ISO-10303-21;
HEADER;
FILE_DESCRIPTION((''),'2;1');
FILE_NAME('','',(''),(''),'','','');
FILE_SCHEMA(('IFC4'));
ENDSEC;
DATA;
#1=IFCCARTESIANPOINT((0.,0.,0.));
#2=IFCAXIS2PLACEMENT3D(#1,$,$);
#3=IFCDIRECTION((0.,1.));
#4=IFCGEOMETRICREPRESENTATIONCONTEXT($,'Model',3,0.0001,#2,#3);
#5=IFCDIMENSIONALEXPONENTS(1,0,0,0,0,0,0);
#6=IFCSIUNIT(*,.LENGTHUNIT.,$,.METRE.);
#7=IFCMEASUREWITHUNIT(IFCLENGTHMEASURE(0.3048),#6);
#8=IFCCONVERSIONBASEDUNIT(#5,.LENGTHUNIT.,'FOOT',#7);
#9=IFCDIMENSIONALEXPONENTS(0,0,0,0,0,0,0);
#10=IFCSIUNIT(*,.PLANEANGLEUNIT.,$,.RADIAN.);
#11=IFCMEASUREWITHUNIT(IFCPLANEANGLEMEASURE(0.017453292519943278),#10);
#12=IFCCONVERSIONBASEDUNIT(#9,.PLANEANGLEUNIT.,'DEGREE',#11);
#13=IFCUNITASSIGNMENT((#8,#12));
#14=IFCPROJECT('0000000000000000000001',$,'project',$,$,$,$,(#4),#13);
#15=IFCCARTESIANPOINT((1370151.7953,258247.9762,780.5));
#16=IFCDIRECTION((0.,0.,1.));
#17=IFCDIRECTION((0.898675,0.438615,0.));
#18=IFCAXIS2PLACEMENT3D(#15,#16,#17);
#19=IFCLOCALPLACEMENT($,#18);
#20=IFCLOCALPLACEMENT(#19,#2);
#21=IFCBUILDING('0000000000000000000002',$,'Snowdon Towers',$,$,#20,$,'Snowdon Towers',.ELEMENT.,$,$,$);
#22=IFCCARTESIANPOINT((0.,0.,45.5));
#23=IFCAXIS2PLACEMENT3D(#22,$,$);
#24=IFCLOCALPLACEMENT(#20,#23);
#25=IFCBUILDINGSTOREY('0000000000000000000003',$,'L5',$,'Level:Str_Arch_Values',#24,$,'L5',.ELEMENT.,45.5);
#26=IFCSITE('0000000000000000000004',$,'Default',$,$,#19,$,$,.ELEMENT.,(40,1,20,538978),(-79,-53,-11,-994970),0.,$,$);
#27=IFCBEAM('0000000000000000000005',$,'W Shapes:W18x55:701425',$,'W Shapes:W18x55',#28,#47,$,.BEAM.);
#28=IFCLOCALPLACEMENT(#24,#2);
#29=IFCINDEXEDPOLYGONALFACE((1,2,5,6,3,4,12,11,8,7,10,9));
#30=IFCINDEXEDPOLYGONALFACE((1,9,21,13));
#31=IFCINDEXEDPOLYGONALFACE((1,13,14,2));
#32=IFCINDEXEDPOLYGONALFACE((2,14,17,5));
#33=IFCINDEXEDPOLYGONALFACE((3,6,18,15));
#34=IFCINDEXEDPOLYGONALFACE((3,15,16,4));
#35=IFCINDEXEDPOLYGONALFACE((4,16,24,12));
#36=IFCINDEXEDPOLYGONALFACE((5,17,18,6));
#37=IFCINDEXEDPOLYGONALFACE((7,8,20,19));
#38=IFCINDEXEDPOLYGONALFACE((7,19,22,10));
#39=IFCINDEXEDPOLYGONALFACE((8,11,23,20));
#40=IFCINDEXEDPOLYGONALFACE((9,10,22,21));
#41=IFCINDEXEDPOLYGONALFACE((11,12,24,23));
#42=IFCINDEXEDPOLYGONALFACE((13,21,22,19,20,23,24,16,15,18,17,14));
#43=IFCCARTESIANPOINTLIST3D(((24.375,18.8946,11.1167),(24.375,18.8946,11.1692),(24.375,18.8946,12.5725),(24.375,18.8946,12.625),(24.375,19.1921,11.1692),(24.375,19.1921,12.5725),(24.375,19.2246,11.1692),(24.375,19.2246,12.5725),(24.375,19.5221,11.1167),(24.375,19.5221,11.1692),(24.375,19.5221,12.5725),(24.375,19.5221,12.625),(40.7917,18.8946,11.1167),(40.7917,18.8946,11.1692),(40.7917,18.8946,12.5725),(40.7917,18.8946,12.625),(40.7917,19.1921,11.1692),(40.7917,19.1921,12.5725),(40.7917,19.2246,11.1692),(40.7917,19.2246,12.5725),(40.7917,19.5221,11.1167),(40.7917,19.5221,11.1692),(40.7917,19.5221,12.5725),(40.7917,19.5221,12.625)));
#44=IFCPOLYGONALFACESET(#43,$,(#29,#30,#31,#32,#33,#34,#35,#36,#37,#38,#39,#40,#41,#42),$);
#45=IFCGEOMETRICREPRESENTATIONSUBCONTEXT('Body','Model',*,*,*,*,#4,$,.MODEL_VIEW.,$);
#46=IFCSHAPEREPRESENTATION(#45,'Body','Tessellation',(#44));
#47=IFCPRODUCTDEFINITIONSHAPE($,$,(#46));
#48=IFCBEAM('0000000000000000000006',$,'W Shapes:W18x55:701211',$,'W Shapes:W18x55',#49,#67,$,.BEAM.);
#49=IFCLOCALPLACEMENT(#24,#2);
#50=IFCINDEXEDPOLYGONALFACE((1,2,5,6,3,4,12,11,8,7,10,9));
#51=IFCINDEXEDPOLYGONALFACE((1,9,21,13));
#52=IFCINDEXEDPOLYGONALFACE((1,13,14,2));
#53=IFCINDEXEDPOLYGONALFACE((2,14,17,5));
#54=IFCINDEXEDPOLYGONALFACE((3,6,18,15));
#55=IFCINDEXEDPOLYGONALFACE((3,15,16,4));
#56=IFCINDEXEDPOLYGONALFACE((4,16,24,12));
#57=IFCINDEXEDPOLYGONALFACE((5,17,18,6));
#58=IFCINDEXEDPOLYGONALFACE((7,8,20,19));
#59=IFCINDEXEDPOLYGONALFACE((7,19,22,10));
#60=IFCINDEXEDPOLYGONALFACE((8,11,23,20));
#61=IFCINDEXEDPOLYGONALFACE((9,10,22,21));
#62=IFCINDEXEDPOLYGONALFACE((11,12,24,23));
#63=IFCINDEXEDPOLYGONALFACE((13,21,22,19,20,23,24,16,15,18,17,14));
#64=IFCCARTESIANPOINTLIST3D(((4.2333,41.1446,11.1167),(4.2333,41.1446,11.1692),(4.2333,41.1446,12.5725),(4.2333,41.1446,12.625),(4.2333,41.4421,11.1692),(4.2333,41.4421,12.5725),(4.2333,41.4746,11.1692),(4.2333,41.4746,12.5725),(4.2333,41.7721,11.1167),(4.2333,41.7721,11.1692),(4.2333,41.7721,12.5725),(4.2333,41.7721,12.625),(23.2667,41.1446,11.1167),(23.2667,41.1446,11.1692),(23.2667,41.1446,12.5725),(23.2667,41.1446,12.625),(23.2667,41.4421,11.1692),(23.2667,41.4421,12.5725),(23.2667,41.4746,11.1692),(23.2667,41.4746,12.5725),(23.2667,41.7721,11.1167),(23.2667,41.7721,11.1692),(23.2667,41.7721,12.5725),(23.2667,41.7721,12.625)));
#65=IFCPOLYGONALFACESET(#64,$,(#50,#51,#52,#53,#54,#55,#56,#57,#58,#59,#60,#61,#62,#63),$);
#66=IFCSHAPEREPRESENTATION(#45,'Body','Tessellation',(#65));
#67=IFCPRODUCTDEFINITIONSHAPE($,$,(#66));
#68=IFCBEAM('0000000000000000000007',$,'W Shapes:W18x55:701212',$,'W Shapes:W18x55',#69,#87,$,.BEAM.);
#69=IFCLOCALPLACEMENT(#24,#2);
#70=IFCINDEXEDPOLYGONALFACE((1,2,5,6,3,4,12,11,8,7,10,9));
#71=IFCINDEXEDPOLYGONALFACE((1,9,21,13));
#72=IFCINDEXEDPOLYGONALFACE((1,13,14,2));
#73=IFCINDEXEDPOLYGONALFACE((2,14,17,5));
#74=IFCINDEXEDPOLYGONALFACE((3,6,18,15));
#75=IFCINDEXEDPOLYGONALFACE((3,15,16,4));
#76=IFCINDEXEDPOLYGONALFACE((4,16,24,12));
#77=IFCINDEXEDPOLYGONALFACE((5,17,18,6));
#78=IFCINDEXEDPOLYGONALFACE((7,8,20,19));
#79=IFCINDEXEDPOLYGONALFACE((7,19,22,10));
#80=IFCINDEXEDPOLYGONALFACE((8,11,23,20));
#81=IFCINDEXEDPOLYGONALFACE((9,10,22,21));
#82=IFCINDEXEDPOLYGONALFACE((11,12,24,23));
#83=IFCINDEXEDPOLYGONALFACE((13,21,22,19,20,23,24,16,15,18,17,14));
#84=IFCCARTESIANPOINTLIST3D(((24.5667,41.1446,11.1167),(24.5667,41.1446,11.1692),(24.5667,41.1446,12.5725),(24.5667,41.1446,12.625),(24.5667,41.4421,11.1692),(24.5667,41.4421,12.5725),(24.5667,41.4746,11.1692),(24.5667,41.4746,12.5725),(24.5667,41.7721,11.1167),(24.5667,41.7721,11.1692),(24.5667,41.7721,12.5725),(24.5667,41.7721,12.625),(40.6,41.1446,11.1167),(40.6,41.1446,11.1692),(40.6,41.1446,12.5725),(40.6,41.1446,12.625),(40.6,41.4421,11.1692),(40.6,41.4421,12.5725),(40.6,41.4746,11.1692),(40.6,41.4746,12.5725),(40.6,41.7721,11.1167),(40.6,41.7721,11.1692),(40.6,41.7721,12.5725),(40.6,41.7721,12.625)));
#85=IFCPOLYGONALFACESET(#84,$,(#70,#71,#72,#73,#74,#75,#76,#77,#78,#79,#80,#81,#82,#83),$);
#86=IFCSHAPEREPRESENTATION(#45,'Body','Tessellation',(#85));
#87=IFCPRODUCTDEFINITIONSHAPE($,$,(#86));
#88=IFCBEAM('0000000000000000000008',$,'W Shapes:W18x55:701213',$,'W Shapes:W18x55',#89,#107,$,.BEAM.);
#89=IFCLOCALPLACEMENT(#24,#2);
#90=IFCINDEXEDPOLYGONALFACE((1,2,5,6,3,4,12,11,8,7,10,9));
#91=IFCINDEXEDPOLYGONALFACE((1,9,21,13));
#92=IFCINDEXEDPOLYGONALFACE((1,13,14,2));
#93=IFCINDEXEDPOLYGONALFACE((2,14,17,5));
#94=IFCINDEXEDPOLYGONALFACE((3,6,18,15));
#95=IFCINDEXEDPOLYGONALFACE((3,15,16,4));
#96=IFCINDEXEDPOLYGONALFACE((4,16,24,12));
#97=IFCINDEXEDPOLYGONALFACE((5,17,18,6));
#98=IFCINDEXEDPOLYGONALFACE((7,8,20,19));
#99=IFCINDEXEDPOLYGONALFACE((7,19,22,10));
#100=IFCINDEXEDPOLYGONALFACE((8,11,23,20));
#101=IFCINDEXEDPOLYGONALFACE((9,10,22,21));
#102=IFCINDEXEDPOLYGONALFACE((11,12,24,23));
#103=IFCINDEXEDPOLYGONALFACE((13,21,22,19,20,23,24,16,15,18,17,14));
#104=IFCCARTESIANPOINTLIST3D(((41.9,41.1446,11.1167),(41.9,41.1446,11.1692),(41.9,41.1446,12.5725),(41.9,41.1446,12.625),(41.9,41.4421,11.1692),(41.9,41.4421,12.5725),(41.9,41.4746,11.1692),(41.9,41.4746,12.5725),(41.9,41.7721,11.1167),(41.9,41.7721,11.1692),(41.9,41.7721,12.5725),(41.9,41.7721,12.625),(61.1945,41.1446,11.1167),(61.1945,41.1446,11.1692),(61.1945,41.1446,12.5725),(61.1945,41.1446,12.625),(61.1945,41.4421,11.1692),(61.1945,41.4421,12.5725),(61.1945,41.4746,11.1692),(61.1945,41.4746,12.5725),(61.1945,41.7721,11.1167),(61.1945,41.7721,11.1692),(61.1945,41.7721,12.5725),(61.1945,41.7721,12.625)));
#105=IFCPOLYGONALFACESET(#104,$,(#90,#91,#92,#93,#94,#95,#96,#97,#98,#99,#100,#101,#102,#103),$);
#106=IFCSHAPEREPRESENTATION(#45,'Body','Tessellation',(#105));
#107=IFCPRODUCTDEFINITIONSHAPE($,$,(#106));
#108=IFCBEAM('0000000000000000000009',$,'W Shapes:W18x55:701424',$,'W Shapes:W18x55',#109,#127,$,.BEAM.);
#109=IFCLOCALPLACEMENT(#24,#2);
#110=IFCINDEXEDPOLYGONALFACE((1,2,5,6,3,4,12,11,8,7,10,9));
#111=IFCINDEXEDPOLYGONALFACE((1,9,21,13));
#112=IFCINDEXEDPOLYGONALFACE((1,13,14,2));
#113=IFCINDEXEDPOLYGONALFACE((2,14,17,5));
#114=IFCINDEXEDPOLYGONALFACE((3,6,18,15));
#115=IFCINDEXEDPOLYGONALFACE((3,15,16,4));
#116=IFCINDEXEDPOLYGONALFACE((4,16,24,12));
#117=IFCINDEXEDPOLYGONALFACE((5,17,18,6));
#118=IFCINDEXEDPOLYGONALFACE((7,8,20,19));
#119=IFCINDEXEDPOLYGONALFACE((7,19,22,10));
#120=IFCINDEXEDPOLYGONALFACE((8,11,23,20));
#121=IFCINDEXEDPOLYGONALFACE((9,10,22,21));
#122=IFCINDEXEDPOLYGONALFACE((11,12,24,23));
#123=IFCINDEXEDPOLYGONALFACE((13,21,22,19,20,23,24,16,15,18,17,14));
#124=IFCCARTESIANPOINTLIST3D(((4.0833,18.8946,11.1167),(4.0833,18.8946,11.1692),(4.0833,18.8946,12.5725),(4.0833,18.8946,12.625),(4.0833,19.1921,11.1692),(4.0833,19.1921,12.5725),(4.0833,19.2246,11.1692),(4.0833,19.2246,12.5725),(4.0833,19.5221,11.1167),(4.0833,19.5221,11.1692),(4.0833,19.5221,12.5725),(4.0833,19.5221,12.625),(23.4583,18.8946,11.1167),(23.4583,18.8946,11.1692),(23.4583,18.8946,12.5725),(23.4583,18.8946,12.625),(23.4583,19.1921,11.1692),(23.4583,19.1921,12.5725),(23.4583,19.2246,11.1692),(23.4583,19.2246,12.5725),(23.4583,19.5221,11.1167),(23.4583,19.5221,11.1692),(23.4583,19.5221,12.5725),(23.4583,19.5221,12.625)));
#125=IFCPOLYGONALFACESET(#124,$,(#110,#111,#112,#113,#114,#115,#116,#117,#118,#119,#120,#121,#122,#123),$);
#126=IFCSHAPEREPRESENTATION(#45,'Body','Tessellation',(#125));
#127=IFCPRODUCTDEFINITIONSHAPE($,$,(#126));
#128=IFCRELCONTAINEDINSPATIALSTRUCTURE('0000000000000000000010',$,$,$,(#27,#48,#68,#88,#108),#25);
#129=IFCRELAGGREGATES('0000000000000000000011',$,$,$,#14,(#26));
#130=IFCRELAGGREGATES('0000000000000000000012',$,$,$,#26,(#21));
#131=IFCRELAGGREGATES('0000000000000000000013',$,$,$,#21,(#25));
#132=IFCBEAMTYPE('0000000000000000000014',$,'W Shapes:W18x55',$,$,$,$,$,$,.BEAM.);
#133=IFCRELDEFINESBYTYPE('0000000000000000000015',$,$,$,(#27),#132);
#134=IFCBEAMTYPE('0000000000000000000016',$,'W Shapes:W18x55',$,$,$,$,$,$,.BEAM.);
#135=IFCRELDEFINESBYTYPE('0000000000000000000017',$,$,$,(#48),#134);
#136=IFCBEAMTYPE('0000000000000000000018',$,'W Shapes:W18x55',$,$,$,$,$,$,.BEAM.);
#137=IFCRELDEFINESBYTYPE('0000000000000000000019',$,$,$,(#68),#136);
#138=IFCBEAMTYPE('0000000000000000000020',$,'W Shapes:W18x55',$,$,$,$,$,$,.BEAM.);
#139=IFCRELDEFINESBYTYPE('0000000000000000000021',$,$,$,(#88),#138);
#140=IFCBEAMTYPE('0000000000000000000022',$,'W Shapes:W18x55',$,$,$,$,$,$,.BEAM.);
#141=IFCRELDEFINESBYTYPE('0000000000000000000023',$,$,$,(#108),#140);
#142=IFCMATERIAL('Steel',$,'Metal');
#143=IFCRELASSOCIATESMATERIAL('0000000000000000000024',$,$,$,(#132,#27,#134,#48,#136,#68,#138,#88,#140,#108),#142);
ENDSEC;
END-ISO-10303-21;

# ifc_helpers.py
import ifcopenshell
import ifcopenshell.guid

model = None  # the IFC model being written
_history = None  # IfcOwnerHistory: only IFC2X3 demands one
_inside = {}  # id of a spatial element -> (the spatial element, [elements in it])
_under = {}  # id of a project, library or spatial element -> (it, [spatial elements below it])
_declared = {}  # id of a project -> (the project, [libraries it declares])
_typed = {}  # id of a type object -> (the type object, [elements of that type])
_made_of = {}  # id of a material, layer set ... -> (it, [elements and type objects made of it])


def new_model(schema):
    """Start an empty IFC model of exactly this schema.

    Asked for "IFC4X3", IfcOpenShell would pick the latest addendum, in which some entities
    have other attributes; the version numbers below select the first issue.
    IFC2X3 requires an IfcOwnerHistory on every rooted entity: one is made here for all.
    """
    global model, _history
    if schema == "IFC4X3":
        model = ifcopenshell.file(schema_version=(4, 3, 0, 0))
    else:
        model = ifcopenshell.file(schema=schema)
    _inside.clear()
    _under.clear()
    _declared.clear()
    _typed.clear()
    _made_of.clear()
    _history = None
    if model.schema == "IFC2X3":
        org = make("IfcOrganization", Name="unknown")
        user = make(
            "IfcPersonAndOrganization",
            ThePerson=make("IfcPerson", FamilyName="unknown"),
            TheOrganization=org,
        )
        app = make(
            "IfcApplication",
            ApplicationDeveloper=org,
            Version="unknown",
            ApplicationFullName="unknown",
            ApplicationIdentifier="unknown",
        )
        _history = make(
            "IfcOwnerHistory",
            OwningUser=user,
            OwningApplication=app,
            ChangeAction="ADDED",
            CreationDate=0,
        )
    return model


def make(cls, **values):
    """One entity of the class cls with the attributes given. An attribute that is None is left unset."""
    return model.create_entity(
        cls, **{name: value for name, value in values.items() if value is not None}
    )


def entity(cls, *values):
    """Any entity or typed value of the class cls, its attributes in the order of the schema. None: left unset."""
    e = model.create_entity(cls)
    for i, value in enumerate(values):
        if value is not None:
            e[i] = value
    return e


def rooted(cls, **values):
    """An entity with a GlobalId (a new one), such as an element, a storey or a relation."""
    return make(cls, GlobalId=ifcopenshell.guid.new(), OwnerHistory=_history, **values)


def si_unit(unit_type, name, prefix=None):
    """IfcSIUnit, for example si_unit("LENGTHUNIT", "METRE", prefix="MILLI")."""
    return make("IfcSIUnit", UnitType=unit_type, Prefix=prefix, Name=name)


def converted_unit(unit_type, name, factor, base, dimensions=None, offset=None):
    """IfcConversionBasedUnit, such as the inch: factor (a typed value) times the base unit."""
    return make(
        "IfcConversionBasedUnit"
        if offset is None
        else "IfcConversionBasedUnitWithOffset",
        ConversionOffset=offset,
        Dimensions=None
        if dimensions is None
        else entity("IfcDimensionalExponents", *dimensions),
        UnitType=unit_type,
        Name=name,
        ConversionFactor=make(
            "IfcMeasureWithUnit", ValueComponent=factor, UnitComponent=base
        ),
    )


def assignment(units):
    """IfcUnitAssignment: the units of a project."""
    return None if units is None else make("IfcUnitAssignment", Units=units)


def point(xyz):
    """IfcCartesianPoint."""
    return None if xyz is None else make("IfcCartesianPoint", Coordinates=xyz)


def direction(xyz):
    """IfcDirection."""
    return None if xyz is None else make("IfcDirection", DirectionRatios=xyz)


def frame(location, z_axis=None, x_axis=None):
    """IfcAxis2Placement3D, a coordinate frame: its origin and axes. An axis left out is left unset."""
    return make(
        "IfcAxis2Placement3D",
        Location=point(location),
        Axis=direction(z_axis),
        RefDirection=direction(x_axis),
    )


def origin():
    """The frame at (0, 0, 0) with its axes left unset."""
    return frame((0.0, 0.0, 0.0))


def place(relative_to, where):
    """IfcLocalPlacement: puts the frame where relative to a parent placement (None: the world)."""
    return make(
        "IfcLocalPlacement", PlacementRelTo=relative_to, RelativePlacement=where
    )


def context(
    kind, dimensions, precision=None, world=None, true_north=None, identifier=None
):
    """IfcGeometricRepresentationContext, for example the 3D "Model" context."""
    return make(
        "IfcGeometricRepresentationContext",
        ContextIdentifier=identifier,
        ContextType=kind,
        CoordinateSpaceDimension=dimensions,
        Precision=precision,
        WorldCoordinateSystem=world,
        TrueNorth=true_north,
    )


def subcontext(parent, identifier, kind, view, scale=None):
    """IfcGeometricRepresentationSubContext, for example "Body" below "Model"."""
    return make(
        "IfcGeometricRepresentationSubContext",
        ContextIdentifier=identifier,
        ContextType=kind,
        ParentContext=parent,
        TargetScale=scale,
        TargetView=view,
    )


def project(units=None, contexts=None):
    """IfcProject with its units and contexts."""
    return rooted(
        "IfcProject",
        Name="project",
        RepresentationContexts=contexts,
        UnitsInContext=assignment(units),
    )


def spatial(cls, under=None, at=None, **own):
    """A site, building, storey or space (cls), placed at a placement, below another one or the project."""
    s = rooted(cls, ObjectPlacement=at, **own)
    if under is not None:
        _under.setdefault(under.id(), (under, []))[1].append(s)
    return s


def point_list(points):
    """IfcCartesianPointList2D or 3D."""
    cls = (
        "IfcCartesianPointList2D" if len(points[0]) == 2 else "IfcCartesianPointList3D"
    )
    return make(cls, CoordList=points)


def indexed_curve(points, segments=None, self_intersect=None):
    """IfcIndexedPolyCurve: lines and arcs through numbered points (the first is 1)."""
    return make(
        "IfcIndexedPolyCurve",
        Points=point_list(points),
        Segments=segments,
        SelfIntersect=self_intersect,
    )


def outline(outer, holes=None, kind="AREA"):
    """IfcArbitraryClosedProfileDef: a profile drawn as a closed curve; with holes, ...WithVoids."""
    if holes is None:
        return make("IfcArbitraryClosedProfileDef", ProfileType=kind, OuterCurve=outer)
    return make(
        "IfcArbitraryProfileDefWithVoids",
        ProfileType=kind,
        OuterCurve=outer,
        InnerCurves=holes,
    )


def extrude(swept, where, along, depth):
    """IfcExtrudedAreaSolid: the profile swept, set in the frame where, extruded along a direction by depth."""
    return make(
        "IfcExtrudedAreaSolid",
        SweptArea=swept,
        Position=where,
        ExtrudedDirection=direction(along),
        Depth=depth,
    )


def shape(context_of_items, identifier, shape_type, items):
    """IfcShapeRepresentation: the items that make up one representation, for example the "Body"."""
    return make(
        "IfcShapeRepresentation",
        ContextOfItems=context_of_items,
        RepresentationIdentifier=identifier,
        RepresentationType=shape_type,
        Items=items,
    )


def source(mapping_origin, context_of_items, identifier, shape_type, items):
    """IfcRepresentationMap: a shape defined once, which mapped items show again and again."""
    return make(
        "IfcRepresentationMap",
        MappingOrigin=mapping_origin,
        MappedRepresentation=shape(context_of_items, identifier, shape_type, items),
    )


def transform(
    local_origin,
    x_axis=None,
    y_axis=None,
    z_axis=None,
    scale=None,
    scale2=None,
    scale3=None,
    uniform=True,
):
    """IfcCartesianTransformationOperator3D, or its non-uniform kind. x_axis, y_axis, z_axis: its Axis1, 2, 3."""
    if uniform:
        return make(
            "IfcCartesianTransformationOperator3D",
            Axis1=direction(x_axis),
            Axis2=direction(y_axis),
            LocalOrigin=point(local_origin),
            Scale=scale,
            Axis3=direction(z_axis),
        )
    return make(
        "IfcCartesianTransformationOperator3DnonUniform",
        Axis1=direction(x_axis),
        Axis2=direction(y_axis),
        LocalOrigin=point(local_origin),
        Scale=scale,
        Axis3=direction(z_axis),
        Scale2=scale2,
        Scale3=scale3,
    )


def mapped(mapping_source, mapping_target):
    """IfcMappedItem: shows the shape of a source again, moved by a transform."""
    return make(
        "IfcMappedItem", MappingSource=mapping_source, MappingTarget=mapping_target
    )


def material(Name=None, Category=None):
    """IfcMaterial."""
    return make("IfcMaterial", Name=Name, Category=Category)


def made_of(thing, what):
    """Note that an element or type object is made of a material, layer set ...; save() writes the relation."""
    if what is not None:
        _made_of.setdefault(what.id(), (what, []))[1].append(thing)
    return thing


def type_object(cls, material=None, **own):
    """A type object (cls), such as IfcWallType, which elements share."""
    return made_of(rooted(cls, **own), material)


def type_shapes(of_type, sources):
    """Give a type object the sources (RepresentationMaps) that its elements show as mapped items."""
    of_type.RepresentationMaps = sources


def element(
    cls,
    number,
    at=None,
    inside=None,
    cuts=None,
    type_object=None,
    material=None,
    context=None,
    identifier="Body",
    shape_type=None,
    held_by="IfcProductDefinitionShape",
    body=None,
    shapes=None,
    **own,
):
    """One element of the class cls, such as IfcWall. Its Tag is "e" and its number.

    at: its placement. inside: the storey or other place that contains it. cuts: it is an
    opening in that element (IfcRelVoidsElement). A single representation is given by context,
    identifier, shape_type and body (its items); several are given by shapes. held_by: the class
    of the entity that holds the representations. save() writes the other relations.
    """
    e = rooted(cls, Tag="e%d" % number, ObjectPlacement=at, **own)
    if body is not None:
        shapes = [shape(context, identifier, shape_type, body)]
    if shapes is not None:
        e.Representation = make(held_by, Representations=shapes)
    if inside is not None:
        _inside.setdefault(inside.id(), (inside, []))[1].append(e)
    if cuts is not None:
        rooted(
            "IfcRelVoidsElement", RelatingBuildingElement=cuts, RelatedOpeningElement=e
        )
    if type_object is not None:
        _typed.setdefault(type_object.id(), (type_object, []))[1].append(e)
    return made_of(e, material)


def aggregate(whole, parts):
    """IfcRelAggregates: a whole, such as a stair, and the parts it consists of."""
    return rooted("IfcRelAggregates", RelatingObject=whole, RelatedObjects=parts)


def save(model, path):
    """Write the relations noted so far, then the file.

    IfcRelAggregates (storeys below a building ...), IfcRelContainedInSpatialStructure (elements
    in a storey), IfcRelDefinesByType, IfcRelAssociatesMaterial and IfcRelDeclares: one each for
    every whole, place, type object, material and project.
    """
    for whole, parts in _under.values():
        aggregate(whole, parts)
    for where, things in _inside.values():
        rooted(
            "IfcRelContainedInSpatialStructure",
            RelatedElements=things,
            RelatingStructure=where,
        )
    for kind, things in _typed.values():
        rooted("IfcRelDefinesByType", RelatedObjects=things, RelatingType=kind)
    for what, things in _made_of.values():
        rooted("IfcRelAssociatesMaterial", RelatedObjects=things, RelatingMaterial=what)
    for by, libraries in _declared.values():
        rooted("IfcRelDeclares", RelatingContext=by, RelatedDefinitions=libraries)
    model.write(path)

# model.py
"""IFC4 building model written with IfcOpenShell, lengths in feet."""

from ifc_helpers import new_model, entity, si_unit, converted_unit, direction, frame, origin, place, context, subcontext, project, spatial, indexed_curve, outline, extrude, source, transform, mapped, material, type_object, type_shapes, element, save


model = new_model("IFC4")

# Units and contexts
model_context = context("Model", 3, precision=0.0001, world=origin(), true_north=direction((0.0, 1.0)))
body_context = subcontext(model_context, "Body", "Model", "MODEL_VIEW")
ifc_project = project(units=[converted_unit("LENGTHUNIT", "FOOT", entity("IfcLengthMeasure", 0.3048), si_unit("LENGTHUNIT", "METRE"), dimensions=[1, 0, 0, 0, 0, 0, 0]), converted_unit("PLANEANGLEUNIT", "DEGREE", entity("IfcPlaneAngleMeasure", 0.017453292519943278), si_unit("PLANEANGLEUNIT", "RADIAN"), dimensions=[0, 0, 0, 0, 0, 0, 0])], contexts=[model_context])

# Site, building, storey
site_placement = place(None, frame((1370151.7953, 258247.9762, 780.5), z_axis=(0.0, 0.0, 1.0), x_axis=(0.898675, 0.438615, 0.0)))
site = spatial("IfcSite", under=ifc_project, at=site_placement, Name="Default", CompositionType="ELEMENT", RefLatitude=(40, 1, 20, 538978), RefLongitude=(-79, -53, -11, -994970), RefElevation=0.0)
building_placement = place(site_placement, origin())
building = spatial("IfcBuilding", under=site, at=building_placement, Name="Snowdon Towers", LongName="Snowdon Towers", CompositionType="ELEMENT")
storey_placement = place(building_placement, frame((0.0, 0.0, 45.5)))
storey = spatial("IfcBuildingStorey", under=building, at=storey_placement, Name="L5", ObjectType="Level:Str_Arch_Values", LongName="L5", CompositionType="ELEMENT", Elevation=45.5)

# Beams
ifc_material = material(Name="Steel", Category="Metal")
beam_type_1 = type_object("IfcBeamType", Name="W Shapes:W18x55", PredefinedType="BEAM", material=ifc_material)
shared_shape_1 = source(origin(), body_context, "Body", "SweptSolid", [
    extrude(outline(indexed_curve([(-0.3138, -0.7017), (-0.3138, -0.7542), (0.3138, -0.7542), (0.3138, -0.7017), (0.0162, -0.7017), (0.0162, 0.7017), (0.3138, 0.7017), (0.3138, 0.7542), (-0.3137, 0.7542), (-0.3137, 0.7017), (-0.0163, 0.7017), (-0.0163, -0.7017), (-0.3138, -0.7017)], self_intersect=False)), frame((-8.2083, 0.0, 0.0), z_axis=(-1.0, 0.0, 0.0), x_axis=(0.0, -1.0, 0.0)), (0.0, 0.0, -1.0), 16.4167),
])
type_shapes(beam_type_1, [shared_shape_1])
beam_1_placement = place(storey_placement, frame((32.5833, 19.2083, 11.8708)))
element("IfcBeam", 1, at=beam_1_placement, inside=storey, type_object=beam_type_1, material=ifc_material, Name="W Shapes:W18x55:701425", ObjectType="W Shapes:W18x55", PredefinedType="BEAM", context=body_context, shape_type="MappedRepresentation", body=[
    mapped(shared_shape_1, transform((0.0, 0.0, 0.0), scale=1.0)),
])
beam_type_2 = type_object("IfcBeamType", Name="W Shapes:W18x55", PredefinedType="BEAM", material=ifc_material)
shared_shape_2 = source(origin(), body_context, "Body", "SweptSolid", [
    extrude(outline(indexed_curve([(-0.3138, -0.7017), (-0.3138, -0.7542), (0.3138, -0.7542), (0.3138, -0.7017), (0.0162, -0.7017), (0.0162, 0.7017), (0.3138, 0.7017), (0.3138, 0.7542), (-0.3137, 0.7542), (-0.3137, 0.7017), (-0.0163, 0.7017), (-0.0163, -0.7017), (-0.3138, -0.7017)], self_intersect=False)), frame((-9.6, 0.0, 0.0), z_axis=(-1.0, 0.0, 0.0), x_axis=(0.0, -1.0, 0.0)), (0.0, 0.0, -1.0), 19.0333),
])
type_shapes(beam_type_2, [shared_shape_2])
beam_2_placement = place(storey_placement, frame((13.8333, 41.4583, 11.8708)))
element("IfcBeam", 2, at=beam_2_placement, inside=storey, type_object=beam_type_2, material=ifc_material, Name="W Shapes:W18x55:701211", ObjectType="W Shapes:W18x55", PredefinedType="BEAM", context=body_context, shape_type="MappedRepresentation", body=[
    mapped(shared_shape_2, transform((0.0, 0.0, 0.0), scale=1.0)),
])
beam_type_3 = type_object("IfcBeamType", Name="W Shapes:W18x55", PredefinedType="BEAM", material=ifc_material)
shared_shape_3 = source(origin(), body_context, "Body", "SweptSolid", [
    extrude(outline(indexed_curve([(-0.3138, -0.7017), (-0.3138, -0.7542), (0.3138, -0.7542), (0.3138, -0.7017), (0.0162, -0.7017), (0.0162, 0.7017), (0.3138, 0.7017), (0.3138, 0.7542), (-0.3137, 0.7542), (-0.3137, 0.7017), (-0.0163, 0.7017), (-0.0163, -0.7017), (-0.3138, -0.7017)], self_intersect=False)), frame((-8.0167, 0.0, 0.0), z_axis=(-1.0, 0.0, 0.0), x_axis=(0.0, -1.0, 0.0)), (0.0, 0.0, -1.0), 16.0333),
])
type_shapes(beam_type_3, [shared_shape_3])
beam_3_placement = place(storey_placement, frame((32.5833, 41.4583, 11.8708)))
element("IfcBeam", 3, at=beam_3_placement, inside=storey, type_object=beam_type_3, material=ifc_material, Name="W Shapes:W18x55:701212", ObjectType="W Shapes:W18x55", PredefinedType="BEAM", context=body_context, shape_type="MappedRepresentation", body=[
    mapped(shared_shape_3, transform((0.0, 0.0, 0.0), scale=1.0)),
])
beam_type_4 = type_object("IfcBeamType", Name="W Shapes:W18x55", PredefinedType="BEAM", material=ifc_material)
shared_shape_4 = source(origin(), body_context, "Body", "SweptSolid", [
    extrude(outline(indexed_curve([(-0.3138, -0.7017), (-0.3138, -0.7542), (0.3138, -0.7542), (0.3138, -0.7017), (0.0162, -0.7017), (0.0162, 0.7017), (0.3138, 0.7017), (0.3138, 0.7542), (-0.3137, 0.7542), (-0.3137, 0.7017), (-0.0163, 0.7017), (-0.0163, -0.7017), (-0.3138, -0.7017)], self_intersect=False)), frame((-9.9242, 0.0, 0.0), z_axis=(-1.0, 0.0, 0.0), x_axis=(0.0, -1.0, 0.0)), (0.0, 0.0, -1.0), 19.2945),
])
type_shapes(beam_type_4, [shared_shape_4])
beam_4_placement = place(storey_placement, frame((51.8242, 41.4583, 11.8708)))
element("IfcBeam", 4, at=beam_4_placement, inside=storey, type_object=beam_type_4, material=ifc_material, Name="W Shapes:W18x55:701213", ObjectType="W Shapes:W18x55", PredefinedType="BEAM", context=body_context, shape_type="MappedRepresentation", body=[
    mapped(shared_shape_4, transform((0.0, 0.0, 0.0), scale=1.0)),
])
beam_type_5 = type_object("IfcBeamType", Name="W Shapes:W18x55", PredefinedType="BEAM", material=ifc_material)
shared_shape_5 = source(origin(), body_context, "Body", "SweptSolid", [
    extrude(outline(indexed_curve([(-0.3138, -0.7017), (-0.3138, -0.7542), (0.3138, -0.7542), (0.3138, -0.7017), (0.0162, -0.7017), (0.0162, 0.7017), (0.3138, 0.7017), (0.3138, 0.7542), (-0.3137, 0.7542), (-0.3137, 0.7017), (-0.0163, 0.7017), (-0.0163, -0.7017), (-0.3138, -0.7017)], self_intersect=False)), frame((-9.9167, 0.0, 0.0), z_axis=(-1.0, 0.0, 0.0), x_axis=(0.0, -1.0, 0.0)), (0.0, 0.0, -1.0), 19.375),
])
type_shapes(beam_type_5, [shared_shape_5])
beam_5_placement = place(storey_placement, frame((14.0, 19.2083, 11.8708)))
element("IfcBeam", 5, at=beam_5_placement, inside=storey, type_object=beam_type_5, material=ifc_material, Name="W Shapes:W18x55:701424", ObjectType="W Shapes:W18x55", PredefinedType="BEAM", context=body_context, shape_type="MappedRepresentation", body=[
    mapped(shared_shape_5, transform((0.0, 0.0, 0.0), scale=1.0)),
])

save(model, "model.ifc")
